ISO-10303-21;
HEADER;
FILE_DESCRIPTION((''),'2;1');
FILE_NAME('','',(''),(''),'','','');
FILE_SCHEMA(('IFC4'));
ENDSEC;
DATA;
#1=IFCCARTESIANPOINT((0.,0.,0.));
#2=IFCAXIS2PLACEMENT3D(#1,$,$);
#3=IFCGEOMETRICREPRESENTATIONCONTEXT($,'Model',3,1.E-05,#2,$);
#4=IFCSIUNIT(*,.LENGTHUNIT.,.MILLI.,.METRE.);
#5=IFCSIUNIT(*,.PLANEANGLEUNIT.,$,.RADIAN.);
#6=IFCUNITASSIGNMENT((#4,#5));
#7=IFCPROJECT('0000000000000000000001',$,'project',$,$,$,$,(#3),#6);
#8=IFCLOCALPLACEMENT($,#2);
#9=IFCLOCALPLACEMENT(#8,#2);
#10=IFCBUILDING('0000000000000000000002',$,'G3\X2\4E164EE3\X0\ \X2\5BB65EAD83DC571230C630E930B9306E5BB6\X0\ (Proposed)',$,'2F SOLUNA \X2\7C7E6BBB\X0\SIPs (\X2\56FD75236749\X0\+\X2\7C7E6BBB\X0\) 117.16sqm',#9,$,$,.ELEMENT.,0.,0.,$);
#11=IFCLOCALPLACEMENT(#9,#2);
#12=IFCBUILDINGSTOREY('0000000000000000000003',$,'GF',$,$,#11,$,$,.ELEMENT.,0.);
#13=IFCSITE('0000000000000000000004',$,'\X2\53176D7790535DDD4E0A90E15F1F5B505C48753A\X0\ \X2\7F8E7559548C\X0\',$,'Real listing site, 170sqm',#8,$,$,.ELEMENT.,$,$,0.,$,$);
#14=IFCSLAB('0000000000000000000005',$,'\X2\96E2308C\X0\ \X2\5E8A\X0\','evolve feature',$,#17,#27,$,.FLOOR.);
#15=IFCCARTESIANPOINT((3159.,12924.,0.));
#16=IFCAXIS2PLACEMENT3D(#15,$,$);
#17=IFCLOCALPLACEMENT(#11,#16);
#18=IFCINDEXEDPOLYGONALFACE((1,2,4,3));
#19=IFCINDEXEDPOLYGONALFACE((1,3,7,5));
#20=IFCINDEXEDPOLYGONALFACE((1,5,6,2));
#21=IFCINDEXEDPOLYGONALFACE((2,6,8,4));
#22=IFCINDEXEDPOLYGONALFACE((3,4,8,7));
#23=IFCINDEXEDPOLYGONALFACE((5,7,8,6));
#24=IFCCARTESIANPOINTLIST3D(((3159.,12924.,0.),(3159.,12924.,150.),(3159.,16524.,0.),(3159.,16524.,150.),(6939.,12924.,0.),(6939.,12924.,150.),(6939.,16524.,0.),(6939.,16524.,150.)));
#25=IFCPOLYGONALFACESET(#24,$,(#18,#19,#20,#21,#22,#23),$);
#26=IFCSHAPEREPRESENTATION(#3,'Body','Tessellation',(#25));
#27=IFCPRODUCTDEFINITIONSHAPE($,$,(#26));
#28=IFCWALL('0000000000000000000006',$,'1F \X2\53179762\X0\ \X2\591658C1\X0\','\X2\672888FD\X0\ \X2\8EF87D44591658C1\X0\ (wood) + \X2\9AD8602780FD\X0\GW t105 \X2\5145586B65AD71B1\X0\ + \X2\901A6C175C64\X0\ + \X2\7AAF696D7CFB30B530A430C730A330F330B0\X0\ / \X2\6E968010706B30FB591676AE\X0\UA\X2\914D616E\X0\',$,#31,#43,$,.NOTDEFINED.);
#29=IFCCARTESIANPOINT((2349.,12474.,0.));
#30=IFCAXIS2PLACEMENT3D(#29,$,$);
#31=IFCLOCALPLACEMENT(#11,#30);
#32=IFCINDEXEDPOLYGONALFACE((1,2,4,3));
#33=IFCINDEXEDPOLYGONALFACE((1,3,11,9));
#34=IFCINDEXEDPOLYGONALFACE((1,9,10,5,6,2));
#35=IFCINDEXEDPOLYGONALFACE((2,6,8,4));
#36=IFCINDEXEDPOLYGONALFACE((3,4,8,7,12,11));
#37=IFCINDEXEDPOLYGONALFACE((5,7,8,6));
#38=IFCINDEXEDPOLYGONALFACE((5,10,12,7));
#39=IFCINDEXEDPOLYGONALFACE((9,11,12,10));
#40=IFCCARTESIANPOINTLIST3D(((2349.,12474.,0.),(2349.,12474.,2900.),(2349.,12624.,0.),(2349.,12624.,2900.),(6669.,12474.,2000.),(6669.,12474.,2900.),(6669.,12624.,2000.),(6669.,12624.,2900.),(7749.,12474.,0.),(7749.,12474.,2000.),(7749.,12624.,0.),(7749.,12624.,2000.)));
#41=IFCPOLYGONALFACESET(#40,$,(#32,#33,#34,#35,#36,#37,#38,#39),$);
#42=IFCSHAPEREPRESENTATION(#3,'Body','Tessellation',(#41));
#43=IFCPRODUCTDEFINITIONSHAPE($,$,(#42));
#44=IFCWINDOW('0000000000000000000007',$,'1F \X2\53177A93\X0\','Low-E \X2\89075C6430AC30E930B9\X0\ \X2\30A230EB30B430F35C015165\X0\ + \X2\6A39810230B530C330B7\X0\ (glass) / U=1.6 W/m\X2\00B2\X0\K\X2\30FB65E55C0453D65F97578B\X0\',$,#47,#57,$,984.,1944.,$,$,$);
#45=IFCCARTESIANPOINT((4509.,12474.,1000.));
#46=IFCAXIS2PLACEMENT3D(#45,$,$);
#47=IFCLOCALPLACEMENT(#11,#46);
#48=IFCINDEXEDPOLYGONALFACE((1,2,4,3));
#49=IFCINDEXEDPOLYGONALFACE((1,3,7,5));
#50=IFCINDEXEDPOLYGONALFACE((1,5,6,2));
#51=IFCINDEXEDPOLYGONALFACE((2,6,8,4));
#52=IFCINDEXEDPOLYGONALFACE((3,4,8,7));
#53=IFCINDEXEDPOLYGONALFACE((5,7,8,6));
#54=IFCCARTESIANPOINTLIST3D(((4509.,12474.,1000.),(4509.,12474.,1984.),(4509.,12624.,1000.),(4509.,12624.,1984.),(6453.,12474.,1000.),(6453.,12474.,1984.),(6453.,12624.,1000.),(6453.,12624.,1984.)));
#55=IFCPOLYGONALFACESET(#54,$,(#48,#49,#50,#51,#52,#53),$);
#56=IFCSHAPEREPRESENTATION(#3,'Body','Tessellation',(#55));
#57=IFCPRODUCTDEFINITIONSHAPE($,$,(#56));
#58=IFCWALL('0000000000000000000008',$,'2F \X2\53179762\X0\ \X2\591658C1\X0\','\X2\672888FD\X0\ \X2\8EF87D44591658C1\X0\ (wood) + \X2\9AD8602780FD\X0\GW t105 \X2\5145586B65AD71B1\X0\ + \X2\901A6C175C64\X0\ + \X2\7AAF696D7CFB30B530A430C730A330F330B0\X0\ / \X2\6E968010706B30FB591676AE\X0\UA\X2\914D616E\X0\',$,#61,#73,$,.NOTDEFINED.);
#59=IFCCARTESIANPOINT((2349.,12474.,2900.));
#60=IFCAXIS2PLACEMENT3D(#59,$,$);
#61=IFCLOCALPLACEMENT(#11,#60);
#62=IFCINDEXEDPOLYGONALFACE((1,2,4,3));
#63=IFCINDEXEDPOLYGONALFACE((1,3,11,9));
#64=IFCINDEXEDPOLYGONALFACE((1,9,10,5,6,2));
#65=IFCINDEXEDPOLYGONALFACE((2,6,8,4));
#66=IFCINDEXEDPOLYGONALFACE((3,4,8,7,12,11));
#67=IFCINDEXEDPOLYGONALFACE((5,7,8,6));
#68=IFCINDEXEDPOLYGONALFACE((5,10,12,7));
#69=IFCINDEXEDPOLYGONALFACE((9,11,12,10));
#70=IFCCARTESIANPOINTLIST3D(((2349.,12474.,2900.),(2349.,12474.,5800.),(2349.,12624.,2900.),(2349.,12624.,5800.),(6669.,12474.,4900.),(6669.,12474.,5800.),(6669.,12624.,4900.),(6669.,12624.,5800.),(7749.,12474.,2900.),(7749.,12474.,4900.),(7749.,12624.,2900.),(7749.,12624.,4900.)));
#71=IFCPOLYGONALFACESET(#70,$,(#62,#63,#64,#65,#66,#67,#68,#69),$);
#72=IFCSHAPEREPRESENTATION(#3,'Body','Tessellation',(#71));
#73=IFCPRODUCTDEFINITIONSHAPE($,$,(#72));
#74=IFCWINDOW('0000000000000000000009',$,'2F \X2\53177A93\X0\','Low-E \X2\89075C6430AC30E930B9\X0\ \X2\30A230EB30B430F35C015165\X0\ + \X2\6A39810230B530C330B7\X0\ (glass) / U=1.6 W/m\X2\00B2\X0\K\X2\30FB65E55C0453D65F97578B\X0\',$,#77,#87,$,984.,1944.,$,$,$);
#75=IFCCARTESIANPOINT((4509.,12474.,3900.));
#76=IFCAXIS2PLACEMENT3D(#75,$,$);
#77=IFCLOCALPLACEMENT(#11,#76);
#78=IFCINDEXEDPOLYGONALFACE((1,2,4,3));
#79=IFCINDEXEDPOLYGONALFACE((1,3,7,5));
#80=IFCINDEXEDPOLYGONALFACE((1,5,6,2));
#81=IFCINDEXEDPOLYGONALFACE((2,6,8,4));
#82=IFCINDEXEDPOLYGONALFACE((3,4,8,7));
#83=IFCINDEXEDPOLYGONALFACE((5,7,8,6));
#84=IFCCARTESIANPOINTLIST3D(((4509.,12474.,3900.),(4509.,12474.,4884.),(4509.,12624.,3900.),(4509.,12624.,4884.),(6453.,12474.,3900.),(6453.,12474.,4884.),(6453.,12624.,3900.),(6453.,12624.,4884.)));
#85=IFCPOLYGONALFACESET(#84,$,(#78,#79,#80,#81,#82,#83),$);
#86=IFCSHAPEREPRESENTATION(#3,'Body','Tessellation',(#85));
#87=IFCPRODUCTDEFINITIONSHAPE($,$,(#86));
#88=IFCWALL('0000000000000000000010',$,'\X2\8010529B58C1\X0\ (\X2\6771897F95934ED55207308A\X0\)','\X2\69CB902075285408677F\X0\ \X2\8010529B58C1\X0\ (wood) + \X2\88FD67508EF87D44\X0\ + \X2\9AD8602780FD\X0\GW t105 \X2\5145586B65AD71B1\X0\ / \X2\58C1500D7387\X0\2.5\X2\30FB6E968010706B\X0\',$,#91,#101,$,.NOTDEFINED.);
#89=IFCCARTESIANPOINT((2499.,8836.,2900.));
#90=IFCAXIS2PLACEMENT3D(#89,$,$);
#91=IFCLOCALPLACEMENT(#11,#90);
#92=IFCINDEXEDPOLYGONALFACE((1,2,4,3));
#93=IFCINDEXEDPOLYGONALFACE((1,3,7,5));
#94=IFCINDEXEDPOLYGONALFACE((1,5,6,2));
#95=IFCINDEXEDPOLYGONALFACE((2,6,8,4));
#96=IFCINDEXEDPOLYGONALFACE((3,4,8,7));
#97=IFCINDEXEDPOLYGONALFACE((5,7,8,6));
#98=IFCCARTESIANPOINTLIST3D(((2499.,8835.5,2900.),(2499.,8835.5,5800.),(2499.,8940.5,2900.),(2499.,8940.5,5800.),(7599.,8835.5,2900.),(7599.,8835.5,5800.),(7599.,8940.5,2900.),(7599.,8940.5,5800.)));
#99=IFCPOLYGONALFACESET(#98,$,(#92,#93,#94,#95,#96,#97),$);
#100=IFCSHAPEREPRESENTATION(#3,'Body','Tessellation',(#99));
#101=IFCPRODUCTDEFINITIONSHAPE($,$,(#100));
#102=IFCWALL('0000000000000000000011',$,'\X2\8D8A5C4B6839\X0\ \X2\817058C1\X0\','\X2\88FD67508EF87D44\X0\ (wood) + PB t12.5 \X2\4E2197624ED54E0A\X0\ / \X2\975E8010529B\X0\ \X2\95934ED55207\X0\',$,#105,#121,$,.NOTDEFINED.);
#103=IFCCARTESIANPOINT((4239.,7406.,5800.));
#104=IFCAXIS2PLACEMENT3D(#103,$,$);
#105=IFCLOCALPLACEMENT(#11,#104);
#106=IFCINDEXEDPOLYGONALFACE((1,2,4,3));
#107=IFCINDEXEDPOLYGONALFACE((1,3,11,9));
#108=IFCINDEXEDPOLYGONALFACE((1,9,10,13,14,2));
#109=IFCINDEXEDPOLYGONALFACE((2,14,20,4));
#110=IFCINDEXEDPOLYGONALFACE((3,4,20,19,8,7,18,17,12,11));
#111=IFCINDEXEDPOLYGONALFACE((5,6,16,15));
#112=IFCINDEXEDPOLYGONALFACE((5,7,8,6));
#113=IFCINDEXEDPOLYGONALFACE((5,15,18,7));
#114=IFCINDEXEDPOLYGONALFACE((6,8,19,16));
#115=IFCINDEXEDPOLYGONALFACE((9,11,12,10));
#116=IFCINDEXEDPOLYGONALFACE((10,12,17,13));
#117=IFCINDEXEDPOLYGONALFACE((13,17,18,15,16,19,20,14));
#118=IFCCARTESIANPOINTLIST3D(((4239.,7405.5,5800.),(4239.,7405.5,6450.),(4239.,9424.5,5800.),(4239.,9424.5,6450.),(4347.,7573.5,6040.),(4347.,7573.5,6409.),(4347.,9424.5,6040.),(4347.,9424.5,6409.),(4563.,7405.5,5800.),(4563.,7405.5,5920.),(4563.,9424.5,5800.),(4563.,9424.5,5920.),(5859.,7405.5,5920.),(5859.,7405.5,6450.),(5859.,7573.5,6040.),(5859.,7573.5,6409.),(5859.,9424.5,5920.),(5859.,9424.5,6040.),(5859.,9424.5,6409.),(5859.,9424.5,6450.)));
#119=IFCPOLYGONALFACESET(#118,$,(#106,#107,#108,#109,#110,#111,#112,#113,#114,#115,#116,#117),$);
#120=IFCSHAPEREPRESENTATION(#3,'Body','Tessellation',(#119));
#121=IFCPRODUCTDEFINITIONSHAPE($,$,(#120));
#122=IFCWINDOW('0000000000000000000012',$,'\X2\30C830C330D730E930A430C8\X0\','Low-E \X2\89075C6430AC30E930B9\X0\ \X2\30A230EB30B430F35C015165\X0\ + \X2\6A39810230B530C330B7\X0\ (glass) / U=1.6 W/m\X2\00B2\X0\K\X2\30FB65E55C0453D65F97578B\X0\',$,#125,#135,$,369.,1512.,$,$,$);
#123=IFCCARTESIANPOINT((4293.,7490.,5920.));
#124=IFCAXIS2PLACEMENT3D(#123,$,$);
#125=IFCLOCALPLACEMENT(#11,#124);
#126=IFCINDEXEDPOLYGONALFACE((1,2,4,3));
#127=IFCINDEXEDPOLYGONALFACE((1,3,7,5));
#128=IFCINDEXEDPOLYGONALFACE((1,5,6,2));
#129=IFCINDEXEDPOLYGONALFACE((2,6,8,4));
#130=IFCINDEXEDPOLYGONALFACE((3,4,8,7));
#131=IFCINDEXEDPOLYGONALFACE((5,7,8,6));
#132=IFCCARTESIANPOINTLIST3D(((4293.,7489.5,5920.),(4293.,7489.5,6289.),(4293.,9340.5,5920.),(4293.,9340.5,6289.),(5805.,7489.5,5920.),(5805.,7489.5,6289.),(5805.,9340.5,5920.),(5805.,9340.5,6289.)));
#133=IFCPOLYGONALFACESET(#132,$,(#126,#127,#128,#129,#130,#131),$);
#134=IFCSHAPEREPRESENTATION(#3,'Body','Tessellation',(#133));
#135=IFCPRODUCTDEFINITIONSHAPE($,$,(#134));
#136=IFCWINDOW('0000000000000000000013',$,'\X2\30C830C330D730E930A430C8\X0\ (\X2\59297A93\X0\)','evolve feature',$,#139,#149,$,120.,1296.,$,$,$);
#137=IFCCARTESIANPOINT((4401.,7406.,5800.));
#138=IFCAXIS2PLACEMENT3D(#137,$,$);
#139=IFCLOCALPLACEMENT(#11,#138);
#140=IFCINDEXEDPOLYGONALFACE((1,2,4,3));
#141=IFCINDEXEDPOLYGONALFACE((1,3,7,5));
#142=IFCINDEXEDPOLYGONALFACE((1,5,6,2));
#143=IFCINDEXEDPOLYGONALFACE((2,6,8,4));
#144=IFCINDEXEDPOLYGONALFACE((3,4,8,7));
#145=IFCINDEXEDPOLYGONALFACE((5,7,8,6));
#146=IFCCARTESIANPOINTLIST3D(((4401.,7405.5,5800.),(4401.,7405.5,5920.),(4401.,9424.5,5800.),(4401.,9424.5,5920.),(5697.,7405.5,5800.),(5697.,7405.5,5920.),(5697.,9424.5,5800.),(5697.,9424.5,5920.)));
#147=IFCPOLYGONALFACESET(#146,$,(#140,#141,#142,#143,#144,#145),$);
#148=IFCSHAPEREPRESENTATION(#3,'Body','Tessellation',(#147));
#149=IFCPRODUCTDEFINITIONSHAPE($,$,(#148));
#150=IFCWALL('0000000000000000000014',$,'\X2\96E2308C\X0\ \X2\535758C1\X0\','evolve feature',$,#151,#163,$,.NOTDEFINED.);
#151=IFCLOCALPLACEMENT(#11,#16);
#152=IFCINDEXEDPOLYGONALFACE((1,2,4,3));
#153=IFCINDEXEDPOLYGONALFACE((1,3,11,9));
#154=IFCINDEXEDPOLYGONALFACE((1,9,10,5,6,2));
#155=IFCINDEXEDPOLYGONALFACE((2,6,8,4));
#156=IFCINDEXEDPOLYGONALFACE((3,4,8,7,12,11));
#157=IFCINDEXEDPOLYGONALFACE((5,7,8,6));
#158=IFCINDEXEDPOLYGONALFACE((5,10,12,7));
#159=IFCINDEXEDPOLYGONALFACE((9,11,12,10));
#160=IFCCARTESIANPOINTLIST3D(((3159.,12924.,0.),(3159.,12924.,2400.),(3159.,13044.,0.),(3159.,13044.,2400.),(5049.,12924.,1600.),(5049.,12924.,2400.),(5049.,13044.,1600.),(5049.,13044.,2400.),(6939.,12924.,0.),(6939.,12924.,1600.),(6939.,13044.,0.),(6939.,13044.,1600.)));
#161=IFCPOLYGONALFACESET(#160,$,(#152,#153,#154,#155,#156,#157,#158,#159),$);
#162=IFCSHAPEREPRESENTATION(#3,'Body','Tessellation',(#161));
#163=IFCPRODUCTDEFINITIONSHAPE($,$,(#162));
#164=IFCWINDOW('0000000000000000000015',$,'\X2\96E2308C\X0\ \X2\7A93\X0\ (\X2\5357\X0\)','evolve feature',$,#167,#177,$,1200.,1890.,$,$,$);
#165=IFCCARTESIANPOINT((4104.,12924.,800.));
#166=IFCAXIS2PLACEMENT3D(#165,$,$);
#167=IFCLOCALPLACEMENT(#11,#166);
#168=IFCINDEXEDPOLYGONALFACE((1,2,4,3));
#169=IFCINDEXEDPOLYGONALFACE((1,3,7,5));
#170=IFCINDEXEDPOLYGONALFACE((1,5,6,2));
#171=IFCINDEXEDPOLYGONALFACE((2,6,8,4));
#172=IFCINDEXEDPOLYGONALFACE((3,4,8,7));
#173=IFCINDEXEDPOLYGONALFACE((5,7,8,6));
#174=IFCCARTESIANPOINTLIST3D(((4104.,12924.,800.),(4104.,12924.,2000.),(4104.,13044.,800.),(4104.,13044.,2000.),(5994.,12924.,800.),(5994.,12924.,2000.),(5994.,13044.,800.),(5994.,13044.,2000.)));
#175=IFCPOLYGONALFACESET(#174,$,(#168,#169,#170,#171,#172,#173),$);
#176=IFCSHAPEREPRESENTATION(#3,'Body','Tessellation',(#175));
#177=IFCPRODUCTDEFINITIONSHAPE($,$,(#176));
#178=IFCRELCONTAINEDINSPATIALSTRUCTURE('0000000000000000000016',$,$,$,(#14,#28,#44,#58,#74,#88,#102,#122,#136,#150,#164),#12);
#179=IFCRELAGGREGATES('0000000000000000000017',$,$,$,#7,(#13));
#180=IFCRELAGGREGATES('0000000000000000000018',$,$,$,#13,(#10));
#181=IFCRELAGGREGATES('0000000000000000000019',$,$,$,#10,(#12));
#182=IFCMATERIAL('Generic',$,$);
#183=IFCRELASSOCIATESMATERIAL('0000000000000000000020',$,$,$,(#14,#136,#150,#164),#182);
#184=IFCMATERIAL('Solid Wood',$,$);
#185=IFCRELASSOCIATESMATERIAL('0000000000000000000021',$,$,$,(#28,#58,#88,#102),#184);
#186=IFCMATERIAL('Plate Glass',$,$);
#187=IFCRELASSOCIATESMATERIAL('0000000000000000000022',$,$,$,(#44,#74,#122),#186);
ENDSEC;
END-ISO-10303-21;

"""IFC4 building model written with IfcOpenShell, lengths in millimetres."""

from ifc_helpers import new_model, si_unit, frame, frame_2d, origin, place, context, project, spatial, rectangle, extrude, material, element, fill, save


model = new_model("IFC4")

# Units and contexts
model_context = context("Model", 3, precision=1e-05, world=origin())
ifc_project = project(units=[si_unit("LENGTHUNIT", "METRE", prefix="MILLI"), si_unit("PLANEANGLEUNIT", "RADIAN")], contexts=[model_context])

# Site, building, storey
site_placement = place(None, origin())
site = spatial("IfcSite", under=ifc_project, at=site_placement, Name="北海道川上郡弟子屈町 美留和", ObjectType="Real listing site, 170sqm", CompositionType="ELEMENT", RefElevation=0.0)
building_placement = place(site_placement, origin())
building = spatial("IfcBuilding", under=site, at=building_placement, Name="G3世代 家庭菜園テラスの家 (Proposed)", ObjectType="2F SOLUNA 籾殻SIPs (国産杉+籾殻) 117.16sqm", CompositionType="ELEMENT", ElevationOfRefHeight=0.0, ElevationOfTerrain=0.0)
storey_placement = place(building_placement, origin())
storey = spatial("IfcBuildingStorey", under=building, at=storey_placement, Name="GF", CompositionType="ELEMENT", Elevation=0.0)

# Slab
ifc_material_1 = material(Name="Generic")
slab_placement = place(storey_placement, frame((3159.0, 12924.0, 0.0)))
element("IfcSlab", 1, at=slab_placement, inside=storey, material=ifc_material_1, Name="離れ 床", Description="evolve feature", PredefinedType="FLOOR", context=model_context, shape_type="SweptSolid", body=[
    extrude(rectangle(XDim=3780.0, YDim=3600.0, at=frame_2d((1890.0, 1800.0))), frame((3159.0, 12924.0, 0.0)), (0.0, 0.0, 1.0), 150.0),
])

# Wall, opening, window
ifc_material_2 = material(Name="Solid Wood")
wall_1_placement = place(storey_placement, frame((2349.0, 12474.0, 0.0)))
wall_1 = element("IfcWall", 2, at=wall_1_placement, inside=storey, material=ifc_material_2, Name="1F 北面 外壁", Description="木製 軸組外壁 (wood) + 高性能GW t105 充填断熱 + 通気層 + 窯業系サイディング / 準耐火・外皮UA配慮", PredefinedType="NOTDEFINED", context=model_context, shape_type="SweptSolid", body=[
    extrude(rectangle(XDim=5400.0, YDim=150.0, at=frame_2d((2700.0, 75.0))), frame((2349.0, 12474.0, 0.0)), (0.0, 0.0, 1.0), 2900.0),
])
opening_1_placement = place(storey_placement, frame((4509.0, 12474.0, 1000.0)))
opening_1 = element("IfcOpeningElement", 3, at=opening_1_placement, cuts=wall_1, PredefinedType="NOTDEFINED", context=model_context, shape_type="SweptSolid", body=[
    extrude(rectangle(XDim=1944.0, YDim=150.0, at=frame_2d((972.0, 75.0))), frame((4509.0, 12474.0, 1000.0)), (0.0, 0.0, 1.0), 984.0),
])
ifc_material_3 = material(Name="Plate Glass")
window_1_placement = place(storey_placement, frame((4509.0, 12474.0, 1000.0)))
window_1 = element("IfcWindow", 4, at=window_1_placement, inside=storey, material=ifc_material_3, Name="1F 北窓", Description="Low-E 複層ガラス アルゴン封入 + 樹脂サッシ (glass) / U=1.6 W/m²K・日射取得型", OverallHeight=984.0, OverallWidth=1944.0, context=model_context, shape_type="SweptSolid", body=[
    extrude(rectangle(XDim=1944.0, YDim=150.0, at=frame_2d((972.0, 75.0))), frame((4509.0, 12474.0, 1000.0)), (0.0, 0.0, 1.0), 984.0),
])
fill(opening_1, window_1)

# Wall, opening, window
wall_2_placement = place(storey_placement, frame((2349.0, 12474.0, 2900.0)))
wall_2 = element("IfcWall", 5, at=wall_2_placement, inside=storey, material=ifc_material_2, Name="2F 北面 外壁", Description="木製 軸組外壁 (wood) + 高性能GW t105 充填断熱 + 通気層 + 窯業系サイディング / 準耐火・外皮UA配慮", PredefinedType="NOTDEFINED", context=model_context, shape_type="SweptSolid", body=[
    extrude(rectangle(XDim=5400.0, YDim=150.0, at=frame_2d((2700.0, 75.0))), frame((2349.0, 12474.0, 2900.0)), (0.0, 0.0, 1.0), 2900.0),
])
opening_2_placement = place(storey_placement, frame((4509.0, 12474.0, 3900.0)))
opening_2 = element("IfcOpeningElement", 6, at=opening_2_placement, cuts=wall_2, PredefinedType="NOTDEFINED", context=model_context, shape_type="SweptSolid", body=[
    extrude(rectangle(XDim=1944.0, YDim=150.0, at=frame_2d((972.0, 75.0))), frame((4509.0, 12474.0, 3900.0)), (0.0, 0.0, 1.0), 984.0),
])
window_2_placement = place(storey_placement, frame((4509.0, 12474.0, 3900.0)))
window_2 = element("IfcWindow", 7, at=window_2_placement, inside=storey, material=ifc_material_3, Name="2F 北窓", Description="Low-E 複層ガラス アルゴン封入 + 樹脂サッシ (glass) / U=1.6 W/m²K・日射取得型", OverallHeight=984.0, OverallWidth=1944.0, context=model_context, shape_type="SweptSolid", body=[
    extrude(rectangle(XDim=1944.0, YDim=150.0, at=frame_2d((972.0, 75.0))), frame((4509.0, 12474.0, 3900.0)), (0.0, 0.0, 1.0), 984.0),
])
fill(opening_2, window_2)

# Wall
wall_3_placement = place(storey_placement, frame((2499.0, 8836.0, 2900.0)))
element("IfcWall", 8, at=wall_3_placement, inside=storey, material=ifc_material_2, Name="耐力壁 (東西間仕切り)", Description="構造用合板 耐力壁 (wood) + 製材軸組 + 高性能GW t105 充填断熱 / 壁倍率2.5・準耐火", PredefinedType="NOTDEFINED", context=model_context, shape_type="SweptSolid", body=[
    extrude(rectangle(XDim=5100.0, YDim=105.0, at=frame_2d((2550.0, 52.0))), frame((2499.0, 8836.0, 2900.0)), (0.0, 0.0, 1.0), 2900.0),
])

# Wall, openings, windows
wall_4_placement = place(storey_placement, frame((4239.0, 7406.0, 5800.0)))
wall_4 = element("IfcWall", 9, at=wall_4_placement, inside=storey, material=ifc_material_2, Name="越屋根 腰壁", Description="製材軸組 (wood) + PB t12.5 両面仕上 / 非耐力 間仕切", PredefinedType="NOTDEFINED", context=model_context, shape_type="SweptSolid", body=[
    extrude(rectangle(XDim=1620.0, YDim=2019.0, at=frame_2d((810.0, 1009.0))), frame((4239.0, 7406.0, 5800.0)), (0.0, 0.0, 1.0), 650.0),
])
opening_3_placement = place(storey_placement, frame((4293.0, 7490.0, 5920.0)))
opening_3 = element("IfcOpeningElement", 10, at=opening_3_placement, cuts=wall_4, PredefinedType="NOTDEFINED", context=model_context, shape_type="SweptSolid", body=[
    extrude(rectangle(XDim=1512.0, YDim=1851.0, at=frame_2d((756.0, 925.0))), frame((4293.0, 7490.0, 5920.0)), (0.0, 0.0, 1.0), 369.0),
])
opening_4_placement = place(storey_placement, frame((4401.0, 7406.0, 5800.0)))
opening_4 = element("IfcOpeningElement", 11, at=opening_4_placement, cuts=wall_4, PredefinedType="NOTDEFINED", context=model_context, shape_type="SweptSolid", body=[
    extrude(rectangle(XDim=1296.0, YDim=2019.0, at=frame_2d((648.0, 1009.0))), frame((4401.0, 7406.0, 5800.0)), (0.0, 0.0, 1.0), 120.0),
])
window_3_placement = place(storey_placement, frame((4293.0, 7490.0, 5920.0)))
window_3 = element("IfcWindow", 12, at=window_3_placement, inside=storey, material=ifc_material_3, Name="トップライト", Description="Low-E 複層ガラス アルゴン封入 + 樹脂サッシ (glass) / U=1.6 W/m²K・日射取得型", OverallHeight=369.0, OverallWidth=1512.0, context=model_context, shape_type="SweptSolid", body=[
    extrude(rectangle(XDim=1512.0, YDim=1851.0, at=frame_2d((756.0, 925.0))), frame((4293.0, 7490.0, 5920.0)), (0.0, 0.0, 1.0), 369.0),
])
fill(opening_3, window_3)
window_4_placement = place(storey_placement, frame((4401.0, 7406.0, 5800.0)))
window_4 = element("IfcWindow", 13, at=window_4_placement, inside=storey, material=ifc_material_1, Name="トップライト (天窓)", Description="evolve feature", OverallHeight=120.0, OverallWidth=1296.0, context=model_context, shape_type="SweptSolid", body=[
    extrude(rectangle(XDim=1296.0, YDim=2019.0, at=frame_2d((648.0, 1009.0))), frame((4401.0, 7406.0, 5800.0)), (0.0, 0.0, 1.0), 120.0),
])
fill(opening_4, window_4)

# Wall, opening, window
wall_5_placement = place(storey_placement, frame((3159.0, 12924.0, 0.0)))
wall_5 = element("IfcWall", 14, at=wall_5_placement, inside=storey, material=ifc_material_1, Name="離れ 南壁", Description="evolve feature", PredefinedType="NOTDEFINED", context=model_context, shape_type="SweptSolid", body=[
    extrude(rectangle(XDim=3780.0, YDim=120.0, at=frame_2d((1890.0, 60.0))), frame((3159.0, 12924.0, 0.0)), (0.0, 0.0, 1.0), 2400.0),
])
opening_5_placement = place(storey_placement, frame((4104.0, 12924.0, 800.0)))
opening_5 = element("IfcOpeningElement", 15, at=opening_5_placement, cuts=wall_5, PredefinedType="NOTDEFINED", context=model_context, shape_type="SweptSolid", body=[
    extrude(rectangle(XDim=1890.0, YDim=120.0, at=frame_2d((945.0, 60.0))), frame((4104.0, 12924.0, 800.0)), (0.0, 0.0, 1.0), 1200.0),
])
window_5_placement = place(storey_placement, frame((4104.0, 12924.0, 800.0)))
window_5 = element("IfcWindow", 16, at=window_5_placement, inside=storey, material=ifc_material_1, Name="離れ 窓 (南)", Description="evolve feature", OverallHeight=1200.0, OverallWidth=1890.0, context=model_context, shape_type="SweptSolid", body=[
    extrude(rectangle(XDim=1890.0, YDim=120.0, at=frame_2d((945.0, 60.0))), frame((4104.0, 12924.0, 800.0)), (0.0, 0.0, 1.0), 1200.0),
])
fill(opening_5, window_5)

save(model, "model.ifc")
